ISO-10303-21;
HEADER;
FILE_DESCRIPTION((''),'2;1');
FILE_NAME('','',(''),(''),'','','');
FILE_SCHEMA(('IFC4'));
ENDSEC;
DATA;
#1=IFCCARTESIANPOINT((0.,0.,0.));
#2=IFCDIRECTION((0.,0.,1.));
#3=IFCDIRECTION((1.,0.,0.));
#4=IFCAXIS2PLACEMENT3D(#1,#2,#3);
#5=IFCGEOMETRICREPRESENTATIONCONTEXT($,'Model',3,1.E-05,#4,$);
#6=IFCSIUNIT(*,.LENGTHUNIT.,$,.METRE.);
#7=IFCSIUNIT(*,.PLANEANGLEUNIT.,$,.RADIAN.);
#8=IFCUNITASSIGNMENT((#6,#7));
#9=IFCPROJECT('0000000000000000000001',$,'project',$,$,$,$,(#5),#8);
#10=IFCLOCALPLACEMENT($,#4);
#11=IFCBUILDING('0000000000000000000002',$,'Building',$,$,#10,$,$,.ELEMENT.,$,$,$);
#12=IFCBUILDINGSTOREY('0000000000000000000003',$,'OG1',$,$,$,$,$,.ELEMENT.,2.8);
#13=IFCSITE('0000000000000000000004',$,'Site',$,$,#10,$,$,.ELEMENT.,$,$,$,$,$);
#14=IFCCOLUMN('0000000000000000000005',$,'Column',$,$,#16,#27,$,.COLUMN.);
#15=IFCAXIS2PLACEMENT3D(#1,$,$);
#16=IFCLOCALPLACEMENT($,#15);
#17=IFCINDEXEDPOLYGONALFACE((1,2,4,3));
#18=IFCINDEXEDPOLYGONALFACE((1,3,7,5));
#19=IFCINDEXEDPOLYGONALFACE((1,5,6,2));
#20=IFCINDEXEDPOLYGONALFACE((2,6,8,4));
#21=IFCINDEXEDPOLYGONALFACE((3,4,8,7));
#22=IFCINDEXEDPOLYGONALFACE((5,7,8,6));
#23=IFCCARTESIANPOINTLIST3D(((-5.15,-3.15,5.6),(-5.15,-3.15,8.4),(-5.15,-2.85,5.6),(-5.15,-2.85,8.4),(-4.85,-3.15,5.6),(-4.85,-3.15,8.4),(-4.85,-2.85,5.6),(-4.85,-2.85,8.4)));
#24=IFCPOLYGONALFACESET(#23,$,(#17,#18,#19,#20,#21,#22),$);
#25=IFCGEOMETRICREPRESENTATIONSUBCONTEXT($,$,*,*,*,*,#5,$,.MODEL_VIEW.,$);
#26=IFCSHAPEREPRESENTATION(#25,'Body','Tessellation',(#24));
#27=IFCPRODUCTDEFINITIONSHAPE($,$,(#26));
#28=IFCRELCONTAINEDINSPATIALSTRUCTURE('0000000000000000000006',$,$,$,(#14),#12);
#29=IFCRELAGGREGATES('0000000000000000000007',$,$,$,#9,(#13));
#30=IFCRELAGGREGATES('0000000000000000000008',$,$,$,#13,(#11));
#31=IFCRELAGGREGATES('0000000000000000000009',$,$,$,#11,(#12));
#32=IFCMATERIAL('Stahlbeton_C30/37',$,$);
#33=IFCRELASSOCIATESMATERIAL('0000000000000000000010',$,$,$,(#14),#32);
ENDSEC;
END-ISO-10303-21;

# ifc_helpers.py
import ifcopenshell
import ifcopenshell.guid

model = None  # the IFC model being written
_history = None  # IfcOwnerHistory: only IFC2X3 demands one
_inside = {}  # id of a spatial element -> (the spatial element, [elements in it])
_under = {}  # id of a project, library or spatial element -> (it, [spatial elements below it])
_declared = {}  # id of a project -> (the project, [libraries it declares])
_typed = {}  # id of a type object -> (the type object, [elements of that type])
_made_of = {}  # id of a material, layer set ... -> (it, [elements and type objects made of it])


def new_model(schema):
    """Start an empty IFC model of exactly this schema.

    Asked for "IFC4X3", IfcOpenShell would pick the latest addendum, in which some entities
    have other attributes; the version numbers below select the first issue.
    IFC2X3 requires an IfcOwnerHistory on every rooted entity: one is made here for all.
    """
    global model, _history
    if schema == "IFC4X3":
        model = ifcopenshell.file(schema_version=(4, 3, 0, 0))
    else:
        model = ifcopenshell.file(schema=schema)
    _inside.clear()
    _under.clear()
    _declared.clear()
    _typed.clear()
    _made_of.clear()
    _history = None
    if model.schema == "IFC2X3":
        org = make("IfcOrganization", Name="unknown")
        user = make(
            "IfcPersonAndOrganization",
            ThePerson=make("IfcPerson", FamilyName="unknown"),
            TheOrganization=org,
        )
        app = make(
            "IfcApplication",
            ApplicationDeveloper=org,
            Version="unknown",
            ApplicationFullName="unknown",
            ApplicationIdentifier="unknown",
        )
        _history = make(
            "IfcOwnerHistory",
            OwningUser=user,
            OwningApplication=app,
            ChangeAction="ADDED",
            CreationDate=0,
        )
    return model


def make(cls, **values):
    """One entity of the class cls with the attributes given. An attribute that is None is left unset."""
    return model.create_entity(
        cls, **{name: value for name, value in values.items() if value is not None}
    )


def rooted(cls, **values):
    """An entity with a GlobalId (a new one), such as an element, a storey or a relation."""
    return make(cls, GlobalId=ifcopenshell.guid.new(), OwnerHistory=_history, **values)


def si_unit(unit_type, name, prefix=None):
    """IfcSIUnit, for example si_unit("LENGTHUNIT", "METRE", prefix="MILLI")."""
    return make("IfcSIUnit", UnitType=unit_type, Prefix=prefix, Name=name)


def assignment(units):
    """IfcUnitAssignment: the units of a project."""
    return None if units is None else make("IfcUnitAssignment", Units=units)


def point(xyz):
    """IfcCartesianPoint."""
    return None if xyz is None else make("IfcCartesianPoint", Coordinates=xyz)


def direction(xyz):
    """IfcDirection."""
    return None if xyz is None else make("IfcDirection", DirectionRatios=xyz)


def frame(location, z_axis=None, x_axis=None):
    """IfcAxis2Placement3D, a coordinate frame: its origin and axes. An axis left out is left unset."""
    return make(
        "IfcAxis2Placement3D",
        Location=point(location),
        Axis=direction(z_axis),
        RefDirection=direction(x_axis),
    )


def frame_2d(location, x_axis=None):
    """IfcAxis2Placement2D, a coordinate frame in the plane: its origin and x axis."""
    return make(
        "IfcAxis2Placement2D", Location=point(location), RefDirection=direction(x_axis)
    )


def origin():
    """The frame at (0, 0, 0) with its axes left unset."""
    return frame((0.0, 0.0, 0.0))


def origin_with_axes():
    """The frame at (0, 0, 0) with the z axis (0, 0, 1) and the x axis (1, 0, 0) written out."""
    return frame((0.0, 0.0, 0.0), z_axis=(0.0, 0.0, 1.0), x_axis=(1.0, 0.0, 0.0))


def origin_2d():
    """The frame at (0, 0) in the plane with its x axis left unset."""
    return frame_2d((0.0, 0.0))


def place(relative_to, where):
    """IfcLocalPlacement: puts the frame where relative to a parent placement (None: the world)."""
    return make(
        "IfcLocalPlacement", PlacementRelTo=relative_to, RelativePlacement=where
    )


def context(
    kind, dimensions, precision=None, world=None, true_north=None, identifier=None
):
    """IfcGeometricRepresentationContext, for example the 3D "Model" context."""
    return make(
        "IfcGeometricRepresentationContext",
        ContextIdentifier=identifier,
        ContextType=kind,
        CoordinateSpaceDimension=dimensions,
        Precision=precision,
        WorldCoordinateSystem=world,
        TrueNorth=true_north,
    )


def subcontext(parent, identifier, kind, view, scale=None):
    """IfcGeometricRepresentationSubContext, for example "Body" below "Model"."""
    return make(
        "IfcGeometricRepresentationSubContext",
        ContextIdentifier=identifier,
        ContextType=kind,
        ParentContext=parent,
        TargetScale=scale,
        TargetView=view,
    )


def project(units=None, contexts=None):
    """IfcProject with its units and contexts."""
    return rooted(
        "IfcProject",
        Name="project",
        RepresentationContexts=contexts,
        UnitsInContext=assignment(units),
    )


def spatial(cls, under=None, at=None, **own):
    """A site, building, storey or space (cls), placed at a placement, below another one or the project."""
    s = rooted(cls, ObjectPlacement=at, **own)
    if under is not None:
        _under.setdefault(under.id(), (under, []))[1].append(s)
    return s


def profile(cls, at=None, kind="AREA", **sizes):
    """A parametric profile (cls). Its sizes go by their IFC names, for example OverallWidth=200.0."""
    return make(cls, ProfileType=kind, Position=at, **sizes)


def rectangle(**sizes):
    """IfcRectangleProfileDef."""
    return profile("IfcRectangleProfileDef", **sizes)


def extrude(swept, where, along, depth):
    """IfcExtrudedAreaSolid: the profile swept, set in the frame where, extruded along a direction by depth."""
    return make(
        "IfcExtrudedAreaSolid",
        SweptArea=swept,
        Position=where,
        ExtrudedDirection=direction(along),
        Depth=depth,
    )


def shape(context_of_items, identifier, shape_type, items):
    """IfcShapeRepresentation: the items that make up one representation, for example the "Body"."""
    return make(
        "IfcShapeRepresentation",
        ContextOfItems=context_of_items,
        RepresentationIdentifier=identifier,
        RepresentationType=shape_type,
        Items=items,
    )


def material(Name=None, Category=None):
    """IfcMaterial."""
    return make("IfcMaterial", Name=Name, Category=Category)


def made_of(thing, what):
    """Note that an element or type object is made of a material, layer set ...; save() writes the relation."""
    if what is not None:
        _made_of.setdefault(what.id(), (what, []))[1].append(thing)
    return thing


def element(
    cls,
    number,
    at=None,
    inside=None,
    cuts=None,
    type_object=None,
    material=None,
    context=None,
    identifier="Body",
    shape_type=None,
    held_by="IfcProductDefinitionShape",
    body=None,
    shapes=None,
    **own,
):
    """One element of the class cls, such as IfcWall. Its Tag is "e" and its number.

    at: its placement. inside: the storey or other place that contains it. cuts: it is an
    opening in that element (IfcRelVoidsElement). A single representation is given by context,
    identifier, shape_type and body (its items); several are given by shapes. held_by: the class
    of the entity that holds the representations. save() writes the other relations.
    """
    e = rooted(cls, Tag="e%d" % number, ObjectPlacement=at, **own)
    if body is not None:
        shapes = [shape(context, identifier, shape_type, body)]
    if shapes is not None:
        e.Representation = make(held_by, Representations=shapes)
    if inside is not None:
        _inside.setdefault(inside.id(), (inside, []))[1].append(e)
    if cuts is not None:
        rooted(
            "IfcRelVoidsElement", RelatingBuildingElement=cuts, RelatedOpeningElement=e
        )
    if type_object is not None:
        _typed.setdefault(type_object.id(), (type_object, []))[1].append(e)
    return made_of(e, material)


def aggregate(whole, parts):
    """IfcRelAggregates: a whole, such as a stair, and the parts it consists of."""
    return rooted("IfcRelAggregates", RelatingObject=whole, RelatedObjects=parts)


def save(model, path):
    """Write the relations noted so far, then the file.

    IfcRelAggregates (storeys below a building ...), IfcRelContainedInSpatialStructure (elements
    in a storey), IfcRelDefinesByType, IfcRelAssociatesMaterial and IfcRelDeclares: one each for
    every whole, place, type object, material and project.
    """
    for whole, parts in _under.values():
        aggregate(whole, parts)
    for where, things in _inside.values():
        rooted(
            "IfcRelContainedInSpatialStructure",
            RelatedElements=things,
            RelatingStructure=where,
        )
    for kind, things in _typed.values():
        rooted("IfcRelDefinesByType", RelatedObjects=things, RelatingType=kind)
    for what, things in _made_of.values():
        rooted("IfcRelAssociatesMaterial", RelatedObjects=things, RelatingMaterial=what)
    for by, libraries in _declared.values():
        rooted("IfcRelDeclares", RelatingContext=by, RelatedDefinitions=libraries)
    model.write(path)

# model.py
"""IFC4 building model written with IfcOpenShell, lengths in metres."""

from ifc_helpers import new_model, si_unit, frame, origin, origin_with_axes, origin_2d, place, context, subcontext, project, spatial, rectangle, extrude, material, element, save


model = new_model("IFC4")

# Units and contexts
model_context = context("Model", 3, precision=1e-05, world=origin_with_axes())
sub_context = subcontext(model_context, None, None, "MODEL_VIEW")
ifc_project = project(units=[si_unit("LENGTHUNIT", "METRE"), si_unit("PLANEANGLEUNIT", "RADIAN")], contexts=[model_context])

# Site, building, storey
placement_1 = place(None, origin_with_axes())
site = spatial("IfcSite", under=ifc_project, at=placement_1, Name="Site", CompositionType="ELEMENT")
building = spatial("IfcBuilding", under=site, at=placement_1, Name="Building", CompositionType="ELEMENT")
storey = spatial("IfcBuildingStorey", under=building, Name="OG1", CompositionType="ELEMENT", Elevation=2.8)

# Column
ifc_material = material(Name="Stahlbeton_C30/37")
placement_2 = place(None, origin_with_axes())
placement_3 = place(placement_2, frame((0.0, 0.0, 2.8)))
column_placement = place(placement_3, frame((-5.0, -3.0, 2.8)))
element("IfcColumn", 1, at=column_placement, inside=storey, material=ifc_material, Name="Column", PredefinedType="COLUMN", context=sub_context, shape_type="SweptSolid", body=[
    extrude(rectangle(XDim=0.3, YDim=0.3, at=origin_2d()), origin(), (0.0, 0.0, 1.0), 2.8),
])

save(model, "model.ifc")
